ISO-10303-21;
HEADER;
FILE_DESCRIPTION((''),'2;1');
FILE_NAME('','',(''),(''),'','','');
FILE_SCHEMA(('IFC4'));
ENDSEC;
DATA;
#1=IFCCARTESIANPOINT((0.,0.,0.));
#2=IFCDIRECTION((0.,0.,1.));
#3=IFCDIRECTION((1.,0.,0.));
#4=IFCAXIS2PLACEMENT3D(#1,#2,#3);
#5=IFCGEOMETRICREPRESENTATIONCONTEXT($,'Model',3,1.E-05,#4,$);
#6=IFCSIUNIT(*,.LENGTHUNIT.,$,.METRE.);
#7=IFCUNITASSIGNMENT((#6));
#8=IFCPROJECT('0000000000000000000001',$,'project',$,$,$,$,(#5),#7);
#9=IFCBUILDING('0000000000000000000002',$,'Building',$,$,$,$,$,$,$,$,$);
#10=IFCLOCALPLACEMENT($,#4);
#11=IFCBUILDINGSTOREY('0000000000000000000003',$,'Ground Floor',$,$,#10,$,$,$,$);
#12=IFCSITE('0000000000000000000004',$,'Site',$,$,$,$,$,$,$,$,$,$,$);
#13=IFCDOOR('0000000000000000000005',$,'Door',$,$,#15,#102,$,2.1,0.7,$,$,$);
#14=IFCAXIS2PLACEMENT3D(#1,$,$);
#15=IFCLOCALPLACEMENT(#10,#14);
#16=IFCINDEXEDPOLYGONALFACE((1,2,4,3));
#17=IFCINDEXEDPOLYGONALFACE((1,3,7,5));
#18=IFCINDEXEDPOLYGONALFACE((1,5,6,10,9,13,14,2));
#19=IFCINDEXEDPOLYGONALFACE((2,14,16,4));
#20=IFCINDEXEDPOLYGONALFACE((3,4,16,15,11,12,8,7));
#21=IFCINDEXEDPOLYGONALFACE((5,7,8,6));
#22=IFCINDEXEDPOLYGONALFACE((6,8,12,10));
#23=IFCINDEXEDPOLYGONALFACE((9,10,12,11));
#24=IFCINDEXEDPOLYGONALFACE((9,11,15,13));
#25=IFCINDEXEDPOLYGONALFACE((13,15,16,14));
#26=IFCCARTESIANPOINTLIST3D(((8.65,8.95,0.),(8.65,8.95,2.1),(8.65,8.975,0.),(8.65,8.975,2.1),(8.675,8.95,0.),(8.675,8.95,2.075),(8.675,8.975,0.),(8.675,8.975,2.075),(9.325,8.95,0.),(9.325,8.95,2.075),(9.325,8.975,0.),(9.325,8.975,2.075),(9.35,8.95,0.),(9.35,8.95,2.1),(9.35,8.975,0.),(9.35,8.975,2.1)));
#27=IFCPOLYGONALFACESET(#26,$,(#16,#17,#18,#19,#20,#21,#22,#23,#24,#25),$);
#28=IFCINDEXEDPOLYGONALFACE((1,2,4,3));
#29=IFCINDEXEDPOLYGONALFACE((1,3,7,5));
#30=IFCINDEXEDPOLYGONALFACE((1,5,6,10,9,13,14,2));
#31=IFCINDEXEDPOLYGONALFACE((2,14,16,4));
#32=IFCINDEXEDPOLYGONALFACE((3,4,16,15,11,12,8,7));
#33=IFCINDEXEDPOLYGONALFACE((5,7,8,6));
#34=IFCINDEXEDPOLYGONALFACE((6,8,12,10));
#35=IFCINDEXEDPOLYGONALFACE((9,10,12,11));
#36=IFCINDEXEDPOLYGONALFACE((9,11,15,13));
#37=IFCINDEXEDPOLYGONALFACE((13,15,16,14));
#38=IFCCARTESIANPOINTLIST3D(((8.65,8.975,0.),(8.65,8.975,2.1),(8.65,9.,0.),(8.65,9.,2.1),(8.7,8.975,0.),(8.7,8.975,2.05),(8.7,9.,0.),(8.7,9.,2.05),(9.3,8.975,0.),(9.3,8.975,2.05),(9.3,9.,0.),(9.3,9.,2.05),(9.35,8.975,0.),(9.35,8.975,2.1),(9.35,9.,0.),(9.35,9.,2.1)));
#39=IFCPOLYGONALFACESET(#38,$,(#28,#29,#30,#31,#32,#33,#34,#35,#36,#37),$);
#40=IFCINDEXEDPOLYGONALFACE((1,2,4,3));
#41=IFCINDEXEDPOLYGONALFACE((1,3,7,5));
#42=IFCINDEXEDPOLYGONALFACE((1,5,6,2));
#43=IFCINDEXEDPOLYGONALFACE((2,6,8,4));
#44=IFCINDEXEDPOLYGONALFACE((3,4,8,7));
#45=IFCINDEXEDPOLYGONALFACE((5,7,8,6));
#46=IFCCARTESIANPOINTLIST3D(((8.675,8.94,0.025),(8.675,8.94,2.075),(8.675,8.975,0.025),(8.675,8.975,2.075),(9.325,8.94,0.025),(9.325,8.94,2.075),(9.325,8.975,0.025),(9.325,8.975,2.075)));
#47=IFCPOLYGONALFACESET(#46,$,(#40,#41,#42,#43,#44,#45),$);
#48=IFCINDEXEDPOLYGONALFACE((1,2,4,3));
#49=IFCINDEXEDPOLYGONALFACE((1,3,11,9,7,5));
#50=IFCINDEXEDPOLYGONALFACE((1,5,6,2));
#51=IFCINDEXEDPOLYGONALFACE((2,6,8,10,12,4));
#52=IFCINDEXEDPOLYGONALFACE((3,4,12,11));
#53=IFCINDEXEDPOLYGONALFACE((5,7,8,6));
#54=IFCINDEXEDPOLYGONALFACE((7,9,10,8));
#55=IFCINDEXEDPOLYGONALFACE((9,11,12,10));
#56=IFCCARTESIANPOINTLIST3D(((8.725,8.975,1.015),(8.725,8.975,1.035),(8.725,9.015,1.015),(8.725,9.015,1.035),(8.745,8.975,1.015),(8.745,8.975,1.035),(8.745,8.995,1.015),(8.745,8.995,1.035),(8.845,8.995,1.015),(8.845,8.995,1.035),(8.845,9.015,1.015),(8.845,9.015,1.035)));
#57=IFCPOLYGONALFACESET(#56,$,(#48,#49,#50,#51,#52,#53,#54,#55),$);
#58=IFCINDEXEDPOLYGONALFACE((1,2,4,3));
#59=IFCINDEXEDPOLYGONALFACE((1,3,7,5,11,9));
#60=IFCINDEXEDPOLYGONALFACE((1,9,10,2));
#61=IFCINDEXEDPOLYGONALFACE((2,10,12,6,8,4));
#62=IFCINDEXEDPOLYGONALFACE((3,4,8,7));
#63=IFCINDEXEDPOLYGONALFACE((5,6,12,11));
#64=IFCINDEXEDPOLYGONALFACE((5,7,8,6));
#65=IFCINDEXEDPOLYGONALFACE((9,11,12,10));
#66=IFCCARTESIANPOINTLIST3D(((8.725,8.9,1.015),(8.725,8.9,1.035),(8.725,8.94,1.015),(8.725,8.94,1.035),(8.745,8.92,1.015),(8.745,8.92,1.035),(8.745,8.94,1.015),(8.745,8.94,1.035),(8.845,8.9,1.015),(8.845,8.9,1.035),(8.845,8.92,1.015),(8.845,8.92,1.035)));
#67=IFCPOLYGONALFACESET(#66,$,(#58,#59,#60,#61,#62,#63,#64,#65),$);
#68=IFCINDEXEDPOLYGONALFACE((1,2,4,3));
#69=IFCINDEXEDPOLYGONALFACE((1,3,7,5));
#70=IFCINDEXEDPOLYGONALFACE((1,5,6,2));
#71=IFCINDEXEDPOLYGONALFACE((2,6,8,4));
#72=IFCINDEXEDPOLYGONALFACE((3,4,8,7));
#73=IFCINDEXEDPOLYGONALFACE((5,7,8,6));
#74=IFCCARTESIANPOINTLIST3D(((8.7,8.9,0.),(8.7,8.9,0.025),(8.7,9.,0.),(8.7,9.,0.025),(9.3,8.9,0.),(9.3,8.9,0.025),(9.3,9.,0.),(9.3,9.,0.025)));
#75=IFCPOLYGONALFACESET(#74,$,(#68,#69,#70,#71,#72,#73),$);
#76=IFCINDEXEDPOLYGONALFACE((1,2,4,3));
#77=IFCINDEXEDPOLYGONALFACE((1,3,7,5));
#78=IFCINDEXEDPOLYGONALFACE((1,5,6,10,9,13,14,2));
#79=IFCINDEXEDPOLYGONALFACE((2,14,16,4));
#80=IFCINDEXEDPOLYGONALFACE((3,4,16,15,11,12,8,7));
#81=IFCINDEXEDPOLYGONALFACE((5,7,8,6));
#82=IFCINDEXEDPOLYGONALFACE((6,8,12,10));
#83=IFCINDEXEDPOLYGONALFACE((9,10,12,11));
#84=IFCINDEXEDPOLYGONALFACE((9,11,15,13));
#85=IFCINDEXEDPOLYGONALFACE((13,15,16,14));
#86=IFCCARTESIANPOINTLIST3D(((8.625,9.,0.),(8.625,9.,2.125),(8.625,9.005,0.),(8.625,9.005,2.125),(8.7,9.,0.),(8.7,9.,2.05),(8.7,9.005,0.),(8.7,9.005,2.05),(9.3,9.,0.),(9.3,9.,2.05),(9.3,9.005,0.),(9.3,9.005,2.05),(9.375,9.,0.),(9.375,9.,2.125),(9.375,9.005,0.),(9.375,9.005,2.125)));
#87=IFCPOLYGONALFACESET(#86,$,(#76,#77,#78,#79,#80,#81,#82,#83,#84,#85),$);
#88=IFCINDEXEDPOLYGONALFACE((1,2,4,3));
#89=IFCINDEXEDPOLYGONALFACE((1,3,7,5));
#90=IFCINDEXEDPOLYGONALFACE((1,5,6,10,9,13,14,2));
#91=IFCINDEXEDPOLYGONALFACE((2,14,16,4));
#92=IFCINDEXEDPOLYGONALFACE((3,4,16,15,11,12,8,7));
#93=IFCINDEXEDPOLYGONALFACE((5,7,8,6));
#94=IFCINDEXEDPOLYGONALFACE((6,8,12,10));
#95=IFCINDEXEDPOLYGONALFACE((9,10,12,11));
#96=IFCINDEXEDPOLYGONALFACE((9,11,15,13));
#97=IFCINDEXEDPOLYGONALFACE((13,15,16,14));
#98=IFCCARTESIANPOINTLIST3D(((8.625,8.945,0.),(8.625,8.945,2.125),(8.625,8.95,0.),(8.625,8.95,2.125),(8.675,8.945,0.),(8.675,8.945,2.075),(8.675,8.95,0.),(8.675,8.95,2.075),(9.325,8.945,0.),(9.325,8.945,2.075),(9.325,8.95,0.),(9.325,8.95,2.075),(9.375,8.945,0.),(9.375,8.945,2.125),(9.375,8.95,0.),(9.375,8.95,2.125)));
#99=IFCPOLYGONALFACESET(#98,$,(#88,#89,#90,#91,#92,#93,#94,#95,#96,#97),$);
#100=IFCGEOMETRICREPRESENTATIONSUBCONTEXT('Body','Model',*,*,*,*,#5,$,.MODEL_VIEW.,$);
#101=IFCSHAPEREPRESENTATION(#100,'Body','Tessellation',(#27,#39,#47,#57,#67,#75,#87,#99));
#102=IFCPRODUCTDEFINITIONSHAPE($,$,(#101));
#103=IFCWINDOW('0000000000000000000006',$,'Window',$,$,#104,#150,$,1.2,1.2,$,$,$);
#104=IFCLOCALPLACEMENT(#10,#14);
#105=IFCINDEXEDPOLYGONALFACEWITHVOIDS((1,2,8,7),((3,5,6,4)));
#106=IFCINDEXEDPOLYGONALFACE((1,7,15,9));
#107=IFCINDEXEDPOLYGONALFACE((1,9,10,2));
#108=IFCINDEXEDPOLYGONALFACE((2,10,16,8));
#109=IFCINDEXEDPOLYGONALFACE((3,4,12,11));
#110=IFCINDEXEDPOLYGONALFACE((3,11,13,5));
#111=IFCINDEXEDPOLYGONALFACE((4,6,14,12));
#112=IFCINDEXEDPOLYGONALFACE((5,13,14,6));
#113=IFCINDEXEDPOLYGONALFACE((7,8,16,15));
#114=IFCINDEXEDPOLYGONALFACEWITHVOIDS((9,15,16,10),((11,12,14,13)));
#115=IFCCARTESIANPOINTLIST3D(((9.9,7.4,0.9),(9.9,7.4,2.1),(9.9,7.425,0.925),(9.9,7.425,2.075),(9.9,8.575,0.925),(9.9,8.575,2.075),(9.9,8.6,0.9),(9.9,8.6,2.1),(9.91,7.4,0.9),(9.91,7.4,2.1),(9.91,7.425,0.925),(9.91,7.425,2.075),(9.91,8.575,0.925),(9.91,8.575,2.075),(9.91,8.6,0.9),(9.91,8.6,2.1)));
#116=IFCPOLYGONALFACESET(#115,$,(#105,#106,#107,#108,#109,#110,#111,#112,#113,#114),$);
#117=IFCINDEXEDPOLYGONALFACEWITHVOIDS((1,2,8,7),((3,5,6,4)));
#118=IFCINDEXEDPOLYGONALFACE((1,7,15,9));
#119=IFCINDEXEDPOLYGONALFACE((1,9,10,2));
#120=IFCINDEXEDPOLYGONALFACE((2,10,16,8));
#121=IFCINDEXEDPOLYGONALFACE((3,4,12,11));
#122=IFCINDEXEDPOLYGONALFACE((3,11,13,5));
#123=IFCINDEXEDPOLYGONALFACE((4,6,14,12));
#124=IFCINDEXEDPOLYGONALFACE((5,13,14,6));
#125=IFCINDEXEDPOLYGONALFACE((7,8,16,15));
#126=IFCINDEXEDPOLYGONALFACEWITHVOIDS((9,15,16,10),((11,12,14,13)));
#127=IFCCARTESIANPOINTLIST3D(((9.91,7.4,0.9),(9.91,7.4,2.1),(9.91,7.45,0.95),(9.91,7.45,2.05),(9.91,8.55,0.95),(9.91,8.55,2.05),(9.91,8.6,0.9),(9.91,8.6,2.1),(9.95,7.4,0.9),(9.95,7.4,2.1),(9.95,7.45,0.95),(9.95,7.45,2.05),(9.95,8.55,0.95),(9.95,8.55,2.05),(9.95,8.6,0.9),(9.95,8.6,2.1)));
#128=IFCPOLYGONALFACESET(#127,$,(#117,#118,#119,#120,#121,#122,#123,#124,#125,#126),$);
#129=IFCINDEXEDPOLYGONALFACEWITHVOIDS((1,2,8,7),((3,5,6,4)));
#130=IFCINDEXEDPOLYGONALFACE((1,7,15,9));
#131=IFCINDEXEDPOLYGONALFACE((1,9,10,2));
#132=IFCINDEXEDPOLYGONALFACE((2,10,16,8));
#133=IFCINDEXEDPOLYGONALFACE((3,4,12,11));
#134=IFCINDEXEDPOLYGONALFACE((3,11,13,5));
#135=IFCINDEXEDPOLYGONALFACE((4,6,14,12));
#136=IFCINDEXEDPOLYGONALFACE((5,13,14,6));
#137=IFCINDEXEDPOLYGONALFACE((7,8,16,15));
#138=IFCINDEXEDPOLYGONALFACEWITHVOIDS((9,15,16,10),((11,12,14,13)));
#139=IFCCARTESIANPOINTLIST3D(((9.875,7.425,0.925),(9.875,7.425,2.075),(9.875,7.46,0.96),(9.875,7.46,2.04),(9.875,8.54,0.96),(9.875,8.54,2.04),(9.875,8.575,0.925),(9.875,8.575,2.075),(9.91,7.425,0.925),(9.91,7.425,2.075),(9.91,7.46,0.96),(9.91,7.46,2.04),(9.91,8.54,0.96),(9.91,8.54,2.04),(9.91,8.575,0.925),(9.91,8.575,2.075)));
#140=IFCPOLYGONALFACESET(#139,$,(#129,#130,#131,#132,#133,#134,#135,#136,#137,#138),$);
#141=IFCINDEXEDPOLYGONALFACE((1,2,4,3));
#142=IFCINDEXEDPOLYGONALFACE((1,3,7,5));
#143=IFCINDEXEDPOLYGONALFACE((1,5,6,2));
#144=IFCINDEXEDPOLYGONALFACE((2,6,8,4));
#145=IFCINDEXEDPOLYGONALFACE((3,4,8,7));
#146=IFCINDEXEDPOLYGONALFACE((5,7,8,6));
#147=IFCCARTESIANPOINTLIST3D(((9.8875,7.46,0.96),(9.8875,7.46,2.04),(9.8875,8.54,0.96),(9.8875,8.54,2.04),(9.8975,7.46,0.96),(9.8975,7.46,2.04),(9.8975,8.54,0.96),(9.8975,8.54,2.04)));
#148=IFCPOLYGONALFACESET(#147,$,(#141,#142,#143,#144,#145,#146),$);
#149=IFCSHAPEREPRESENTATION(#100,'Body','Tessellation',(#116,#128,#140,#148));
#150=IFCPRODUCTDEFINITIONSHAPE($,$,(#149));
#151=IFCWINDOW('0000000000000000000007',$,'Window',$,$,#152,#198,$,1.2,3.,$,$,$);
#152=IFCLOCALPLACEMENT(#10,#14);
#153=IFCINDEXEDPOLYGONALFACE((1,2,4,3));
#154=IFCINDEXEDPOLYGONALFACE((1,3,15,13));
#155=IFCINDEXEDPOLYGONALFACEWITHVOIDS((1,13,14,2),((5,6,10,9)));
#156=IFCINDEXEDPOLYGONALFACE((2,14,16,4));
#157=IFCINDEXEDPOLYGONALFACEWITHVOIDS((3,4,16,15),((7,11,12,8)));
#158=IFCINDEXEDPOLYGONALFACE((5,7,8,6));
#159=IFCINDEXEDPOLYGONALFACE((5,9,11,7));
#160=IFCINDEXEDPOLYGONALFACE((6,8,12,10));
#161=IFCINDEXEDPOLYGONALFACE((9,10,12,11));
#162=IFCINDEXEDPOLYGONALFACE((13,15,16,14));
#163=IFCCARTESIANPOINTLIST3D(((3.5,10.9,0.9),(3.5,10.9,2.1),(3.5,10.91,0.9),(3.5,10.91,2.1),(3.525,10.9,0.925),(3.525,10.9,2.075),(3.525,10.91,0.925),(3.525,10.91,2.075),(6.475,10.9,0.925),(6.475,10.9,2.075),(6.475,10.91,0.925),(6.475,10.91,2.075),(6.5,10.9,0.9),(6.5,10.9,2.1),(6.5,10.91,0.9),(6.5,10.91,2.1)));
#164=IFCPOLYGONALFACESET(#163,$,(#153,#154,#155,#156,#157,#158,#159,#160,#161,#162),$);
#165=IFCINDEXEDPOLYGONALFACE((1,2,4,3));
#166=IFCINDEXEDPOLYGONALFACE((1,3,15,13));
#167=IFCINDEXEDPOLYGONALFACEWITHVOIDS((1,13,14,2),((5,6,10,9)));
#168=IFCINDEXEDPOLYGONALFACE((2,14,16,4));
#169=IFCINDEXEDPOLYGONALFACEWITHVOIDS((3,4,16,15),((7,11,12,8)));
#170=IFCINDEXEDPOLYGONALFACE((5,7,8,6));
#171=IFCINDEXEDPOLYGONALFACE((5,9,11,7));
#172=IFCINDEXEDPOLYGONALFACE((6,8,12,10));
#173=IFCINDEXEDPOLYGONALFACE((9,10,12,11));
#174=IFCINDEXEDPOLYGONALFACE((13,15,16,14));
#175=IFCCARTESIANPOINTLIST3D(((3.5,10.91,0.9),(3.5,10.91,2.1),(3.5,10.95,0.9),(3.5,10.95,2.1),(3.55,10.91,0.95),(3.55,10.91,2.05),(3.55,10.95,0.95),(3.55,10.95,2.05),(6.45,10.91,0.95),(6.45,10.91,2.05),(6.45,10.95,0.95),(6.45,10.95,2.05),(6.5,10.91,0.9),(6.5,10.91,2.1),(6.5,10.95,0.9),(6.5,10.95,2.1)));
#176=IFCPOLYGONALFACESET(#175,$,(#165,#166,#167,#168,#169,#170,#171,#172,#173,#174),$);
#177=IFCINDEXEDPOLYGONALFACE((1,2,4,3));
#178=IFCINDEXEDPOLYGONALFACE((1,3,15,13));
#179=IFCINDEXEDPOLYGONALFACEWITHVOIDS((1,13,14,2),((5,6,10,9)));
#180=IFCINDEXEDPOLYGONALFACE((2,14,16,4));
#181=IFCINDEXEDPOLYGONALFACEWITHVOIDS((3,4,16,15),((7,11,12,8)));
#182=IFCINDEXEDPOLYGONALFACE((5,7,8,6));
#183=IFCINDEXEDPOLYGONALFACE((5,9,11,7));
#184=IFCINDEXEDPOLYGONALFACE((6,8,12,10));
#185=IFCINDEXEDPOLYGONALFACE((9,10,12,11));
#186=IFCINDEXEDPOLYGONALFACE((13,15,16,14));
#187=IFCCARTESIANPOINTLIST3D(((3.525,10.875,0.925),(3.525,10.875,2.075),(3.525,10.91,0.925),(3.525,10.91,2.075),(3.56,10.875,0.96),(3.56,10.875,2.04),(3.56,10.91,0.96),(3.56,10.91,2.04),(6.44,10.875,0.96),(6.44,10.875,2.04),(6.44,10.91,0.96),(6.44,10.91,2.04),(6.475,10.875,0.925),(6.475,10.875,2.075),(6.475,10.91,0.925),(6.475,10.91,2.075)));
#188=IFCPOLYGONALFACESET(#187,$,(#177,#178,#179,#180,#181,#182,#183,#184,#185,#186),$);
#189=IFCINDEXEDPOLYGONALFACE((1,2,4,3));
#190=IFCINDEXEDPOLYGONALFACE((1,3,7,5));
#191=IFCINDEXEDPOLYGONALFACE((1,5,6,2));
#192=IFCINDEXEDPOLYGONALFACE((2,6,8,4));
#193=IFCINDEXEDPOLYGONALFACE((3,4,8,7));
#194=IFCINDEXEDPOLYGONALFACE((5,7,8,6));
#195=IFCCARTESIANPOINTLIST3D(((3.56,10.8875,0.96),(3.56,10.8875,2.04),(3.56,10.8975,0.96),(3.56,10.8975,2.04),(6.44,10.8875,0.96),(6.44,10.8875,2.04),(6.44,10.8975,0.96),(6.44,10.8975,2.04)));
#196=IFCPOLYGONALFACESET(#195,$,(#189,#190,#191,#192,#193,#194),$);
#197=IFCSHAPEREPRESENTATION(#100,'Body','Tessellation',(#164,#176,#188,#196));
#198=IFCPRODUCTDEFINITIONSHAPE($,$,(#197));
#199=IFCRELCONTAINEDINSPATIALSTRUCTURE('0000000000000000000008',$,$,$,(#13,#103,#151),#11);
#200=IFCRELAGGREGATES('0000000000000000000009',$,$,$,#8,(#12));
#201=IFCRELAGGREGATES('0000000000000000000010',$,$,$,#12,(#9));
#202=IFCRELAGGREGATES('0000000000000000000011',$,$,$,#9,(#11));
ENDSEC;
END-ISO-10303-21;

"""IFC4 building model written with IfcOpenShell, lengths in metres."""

from ifc_helpers import new_model, si_unit, frame, origin_with_axes, place, context, subcontext, project, spatial, line, indexed_curve, outline, extrude, element, save


model = new_model("IFC4")

# Units and contexts
model_context = context("Model", 3, precision=1e-05, world=origin_with_axes())
body_context = subcontext(model_context, "Body", "Model", "MODEL_VIEW")
ifc_project = project(units=[si_unit("LENGTHUNIT", "METRE")], contexts=[model_context])

# Site, building, storey
site = spatial("IfcSite", under=ifc_project, Name="Site")
building = spatial("IfcBuilding", under=site, Name="Building")
storey_placement = place(None, origin_with_axes())
storey = spatial("IfcBuildingStorey", under=building, at=storey_placement, Name="Ground Floor")

# Door
door_1_placement = place(storey_placement, frame((9.35, 9.0, 0.0), z_axis=(0.0, 0.0, 1.0), x_axis=(-1.0, 0.0, 0.0)))
element("IfcDoor", 1, at=door_1_placement, inside=storey, Name="Door", OverallHeight=2.1, OverallWidth=0.7, context=body_context, shape_type="SweptSolid", body=[
    extrude(outline(indexed_curve([(0.0, 0.0), (0.0, 2.1), (0.7, 2.1), (0.7, 0.0), (0.675, 0.0), (0.675, 2.075), (0.025, 2.075), (0.025, 0.0)], segments=[line(1, 2, 3, 4, 5, 6, 7, 8, 1)])), frame((0.0, 0.025, 0.0), z_axis=(0.0, -1.0, 0.0), x_axis=(1.0, 0.0, 0.0)), (0.0, 0.0, -1.0), 0.025),
    extrude(outline(indexed_curve([(0.0, 0.0), (0.0, 2.1), (0.7, 2.1), (0.7, 0.0), (0.65, 0.0), (0.65, 2.05), (0.05, 2.05), (0.05, 0.0)], segments=[line(1, 2, 3, 4, 5, 6, 7, 8, 1)])), frame((0.0, 0.0, 0.0), z_axis=(0.0, -1.0, 0.0), x_axis=(1.0, 0.0, 0.0)), (0.0, 0.0, -1.0), 0.025),
    extrude(outline(indexed_curve([(0.0, 0.0), (0.65, 0.0), (0.65, 0.035), (0.0, 0.035)], segments=[line(1, 2, 3, 4, 1)])), frame((0.025, 0.025, 0.025), z_axis=(0.0, 0.0, 1.0), x_axis=(1.0, 0.0, 0.0)), (0.0, 0.0, 1.0), 2.05),
    extrude(outline(indexed_curve([(0.0, 0.0), (0.0, -0.04), (-0.12, -0.04), (-0.12, -0.02), (-0.02, -0.02), (-0.02, 0.0)], segments=[line(1, 2, 3, 4, 5, 6, 1)])), frame((0.625, 0.025, 1.015), z_axis=(0.0, 0.0, 1.0), x_axis=(1.0, 0.0, 0.0)), (0.0, 0.0, 1.0), 0.02),
    extrude(outline(indexed_curve([(0.0, 0.0), (0.0, 0.04), (-0.12, 0.04), (-0.12, 0.02), (-0.02, 0.02), (-0.02, 0.0)], segments=[line(1, 2, 3, 4, 5, 6, 1)])), frame((0.625, 0.06, 1.015), z_axis=(0.0, 0.0, 1.0), x_axis=(1.0, 0.0, 0.0)), (0.0, 0.0, 1.0), 0.02),
    extrude(outline(indexed_curve([(0.0, 0.0), (0.6, 0.0), (0.6, 0.1), (0.0, 0.1)], segments=[line(1, 2, 3, 4, 1)])), frame((0.05, 0.0, 0.0), z_axis=(0.0, 0.0, 1.0), x_axis=(1.0, 0.0, 0.0)), (0.0, 0.0, 1.0), 0.025),
    extrude(outline(indexed_curve([(0.0, 0.0), (0.0, 2.125), (0.75, 2.125), (0.75, 0.0), (0.675, 0.0), (0.675, 2.05), (0.075, 2.05), (0.075, 0.0)], segments=[line(1, 2, 3, 4, 5, 6, 7, 8, 1)])), frame((-0.025, -0.005, 0.0), z_axis=(0.0, -1.0, 0.0), x_axis=(1.0, 0.0, 0.0)), (0.0, 0.0, -1.0), 0.005),
    extrude(outline(indexed_curve([(0.0, 0.0), (0.0, 2.125), (0.75, 2.125), (0.75, 0.0), (0.7, 0.0), (0.7, 2.075), (0.05, 2.075), (0.05, 0.0)], segments=[line(1, 2, 3, 4, 5, 6, 7, 8, 1)])), frame((-0.025, 0.05, 0.0), z_axis=(0.0, -1.0, 0.0), x_axis=(1.0, 0.0, 0.0)), (0.0, 0.0, -1.0), 0.005),
])

# Windows
window_1_placement = place(storey_placement, frame((10.0, 7.4, 0.9), z_axis=(0.0, 0.0, 1.0), x_axis=(0.0, 1.0, 0.0)))
element("IfcWindow", 2, at=window_1_placement, inside=storey, Name="Window", OverallHeight=1.2, OverallWidth=1.2, context=body_context, shape_type="SweptSolid", body=[
    extrude(outline(indexed_curve([(0.0, 0.0), (1.2, 0.0), (1.2, 1.2), (0.0, 1.2)], segments=[line(1, 2, 3, 4, 1)]), holes=[indexed_curve([(0.025, 0.025), (1.175, 0.025), (1.175, 1.175), (0.025, 1.175)], segments=[line(1, 2, 3, 4, 1)])]), frame((0.0, 0.09, 0.0), z_axis=(0.0, -1.0, 0.0), x_axis=(1.0, 0.0, 0.0)), (0.0, 0.0, -1.0), 0.01),
    extrude(outline(indexed_curve([(0.0, 0.0), (1.2, 0.0), (1.2, 1.2), (0.0, 1.2)], segments=[line(1, 2, 3, 4, 1)]), holes=[indexed_curve([(0.05, 0.05), (1.15, 0.05), (1.15, 1.15), (0.05, 1.15)], segments=[line(1, 2, 3, 4, 1)])]), frame((0.0, 0.05, 0.0), z_axis=(0.0, -1.0, 0.0), x_axis=(1.0, 0.0, 0.0)), (0.0, 0.0, -1.0), 0.04),
    extrude(outline(indexed_curve([(0.0, 0.0), (1.15, 0.0), (1.15, 1.15), (0.0, 1.15)], segments=[line(1, 2, 3, 4, 1)]), holes=[indexed_curve([(0.035, 0.035), (1.115, 0.035), (1.115, 1.115), (0.035, 1.115)], segments=[line(1, 2, 3, 4, 1)])]), frame((0.025, 0.09, 0.025), z_axis=(0.0, -1.0, 0.0), x_axis=(1.0, 0.0, 0.0)), (0.0, 0.0, -1.0), 0.035),
    extrude(outline(indexed_curve([(0.035, 0.035), (1.115, 0.035), (1.115, 1.115), (0.035, 1.115)], segments=[line(1, 2, 3, 4, 1)])), frame((0.025, 0.1025, 0.025), z_axis=(0.0, -1.0, 0.0), x_axis=(1.0, 0.0, 0.0)), (0.0, 0.0, -1.0), 0.01),
])
window_2_placement = place(storey_placement, frame((6.5, 11.0, 0.9), z_axis=(0.0, 0.0, 1.0), x_axis=(-1.0, 0.0, 0.0)))
element("IfcWindow", 3, at=window_2_placement, inside=storey, Name="Window", OverallHeight=1.2, OverallWidth=3.0, context=body_context, shape_type="SweptSolid", body=[
    extrude(outline(indexed_curve([(0.0, 0.0), (3.0, 0.0), (3.0, 1.2), (0.0, 1.2)], segments=[line(1, 2, 3, 4, 1)]), holes=[indexed_curve([(0.025, 0.025), (2.975, 0.025), (2.975, 1.175), (0.025, 1.175)], segments=[line(1, 2, 3, 4, 1)])]), frame((0.0, 0.09, 0.0), z_axis=(0.0, -1.0, 0.0), x_axis=(1.0, 0.0, 0.0)), (0.0, 0.0, -1.0), 0.01),
    extrude(outline(indexed_curve([(0.0, 0.0), (3.0, 0.0), (3.0, 1.2), (0.0, 1.2)], segments=[line(1, 2, 3, 4, 1)]), holes=[indexed_curve([(0.05, 0.05), (2.95, 0.05), (2.95, 1.15), (0.05, 1.15)], segments=[line(1, 2, 3, 4, 1)])]), frame((0.0, 0.05, 0.0), z_axis=(0.0, -1.0, 0.0), x_axis=(1.0, 0.0, 0.0)), (0.0, 0.0, -1.0), 0.04),
    extrude(outline(indexed_curve([(0.0, 0.0), (2.95, 0.0), (2.95, 1.15), (0.0, 1.15)], segments=[line(1, 2, 3, 4, 1)]), holes=[indexed_curve([(0.035, 0.035), (2.915, 0.035), (2.915, 1.115), (0.035, 1.115)], segments=[line(1, 2, 3, 4, 1)])]), frame((0.025, 0.09, 0.025), z_axis=(0.0, -1.0, 0.0), x_axis=(1.0, 0.0, 0.0)), (0.0, 0.0, -1.0), 0.035),
    extrude(outline(indexed_curve([(0.035, 0.035), (2.915, 0.035), (2.915, 1.115), (0.035, 1.115)], segments=[line(1, 2, 3, 4, 1)])), frame((0.025, 0.1025, 0.025), z_axis=(0.0, -1.0, 0.0), x_axis=(1.0, 0.0, 0.0)), (0.0, 0.0, -1.0), 0.01),
])

save(model, "model.ifc")
